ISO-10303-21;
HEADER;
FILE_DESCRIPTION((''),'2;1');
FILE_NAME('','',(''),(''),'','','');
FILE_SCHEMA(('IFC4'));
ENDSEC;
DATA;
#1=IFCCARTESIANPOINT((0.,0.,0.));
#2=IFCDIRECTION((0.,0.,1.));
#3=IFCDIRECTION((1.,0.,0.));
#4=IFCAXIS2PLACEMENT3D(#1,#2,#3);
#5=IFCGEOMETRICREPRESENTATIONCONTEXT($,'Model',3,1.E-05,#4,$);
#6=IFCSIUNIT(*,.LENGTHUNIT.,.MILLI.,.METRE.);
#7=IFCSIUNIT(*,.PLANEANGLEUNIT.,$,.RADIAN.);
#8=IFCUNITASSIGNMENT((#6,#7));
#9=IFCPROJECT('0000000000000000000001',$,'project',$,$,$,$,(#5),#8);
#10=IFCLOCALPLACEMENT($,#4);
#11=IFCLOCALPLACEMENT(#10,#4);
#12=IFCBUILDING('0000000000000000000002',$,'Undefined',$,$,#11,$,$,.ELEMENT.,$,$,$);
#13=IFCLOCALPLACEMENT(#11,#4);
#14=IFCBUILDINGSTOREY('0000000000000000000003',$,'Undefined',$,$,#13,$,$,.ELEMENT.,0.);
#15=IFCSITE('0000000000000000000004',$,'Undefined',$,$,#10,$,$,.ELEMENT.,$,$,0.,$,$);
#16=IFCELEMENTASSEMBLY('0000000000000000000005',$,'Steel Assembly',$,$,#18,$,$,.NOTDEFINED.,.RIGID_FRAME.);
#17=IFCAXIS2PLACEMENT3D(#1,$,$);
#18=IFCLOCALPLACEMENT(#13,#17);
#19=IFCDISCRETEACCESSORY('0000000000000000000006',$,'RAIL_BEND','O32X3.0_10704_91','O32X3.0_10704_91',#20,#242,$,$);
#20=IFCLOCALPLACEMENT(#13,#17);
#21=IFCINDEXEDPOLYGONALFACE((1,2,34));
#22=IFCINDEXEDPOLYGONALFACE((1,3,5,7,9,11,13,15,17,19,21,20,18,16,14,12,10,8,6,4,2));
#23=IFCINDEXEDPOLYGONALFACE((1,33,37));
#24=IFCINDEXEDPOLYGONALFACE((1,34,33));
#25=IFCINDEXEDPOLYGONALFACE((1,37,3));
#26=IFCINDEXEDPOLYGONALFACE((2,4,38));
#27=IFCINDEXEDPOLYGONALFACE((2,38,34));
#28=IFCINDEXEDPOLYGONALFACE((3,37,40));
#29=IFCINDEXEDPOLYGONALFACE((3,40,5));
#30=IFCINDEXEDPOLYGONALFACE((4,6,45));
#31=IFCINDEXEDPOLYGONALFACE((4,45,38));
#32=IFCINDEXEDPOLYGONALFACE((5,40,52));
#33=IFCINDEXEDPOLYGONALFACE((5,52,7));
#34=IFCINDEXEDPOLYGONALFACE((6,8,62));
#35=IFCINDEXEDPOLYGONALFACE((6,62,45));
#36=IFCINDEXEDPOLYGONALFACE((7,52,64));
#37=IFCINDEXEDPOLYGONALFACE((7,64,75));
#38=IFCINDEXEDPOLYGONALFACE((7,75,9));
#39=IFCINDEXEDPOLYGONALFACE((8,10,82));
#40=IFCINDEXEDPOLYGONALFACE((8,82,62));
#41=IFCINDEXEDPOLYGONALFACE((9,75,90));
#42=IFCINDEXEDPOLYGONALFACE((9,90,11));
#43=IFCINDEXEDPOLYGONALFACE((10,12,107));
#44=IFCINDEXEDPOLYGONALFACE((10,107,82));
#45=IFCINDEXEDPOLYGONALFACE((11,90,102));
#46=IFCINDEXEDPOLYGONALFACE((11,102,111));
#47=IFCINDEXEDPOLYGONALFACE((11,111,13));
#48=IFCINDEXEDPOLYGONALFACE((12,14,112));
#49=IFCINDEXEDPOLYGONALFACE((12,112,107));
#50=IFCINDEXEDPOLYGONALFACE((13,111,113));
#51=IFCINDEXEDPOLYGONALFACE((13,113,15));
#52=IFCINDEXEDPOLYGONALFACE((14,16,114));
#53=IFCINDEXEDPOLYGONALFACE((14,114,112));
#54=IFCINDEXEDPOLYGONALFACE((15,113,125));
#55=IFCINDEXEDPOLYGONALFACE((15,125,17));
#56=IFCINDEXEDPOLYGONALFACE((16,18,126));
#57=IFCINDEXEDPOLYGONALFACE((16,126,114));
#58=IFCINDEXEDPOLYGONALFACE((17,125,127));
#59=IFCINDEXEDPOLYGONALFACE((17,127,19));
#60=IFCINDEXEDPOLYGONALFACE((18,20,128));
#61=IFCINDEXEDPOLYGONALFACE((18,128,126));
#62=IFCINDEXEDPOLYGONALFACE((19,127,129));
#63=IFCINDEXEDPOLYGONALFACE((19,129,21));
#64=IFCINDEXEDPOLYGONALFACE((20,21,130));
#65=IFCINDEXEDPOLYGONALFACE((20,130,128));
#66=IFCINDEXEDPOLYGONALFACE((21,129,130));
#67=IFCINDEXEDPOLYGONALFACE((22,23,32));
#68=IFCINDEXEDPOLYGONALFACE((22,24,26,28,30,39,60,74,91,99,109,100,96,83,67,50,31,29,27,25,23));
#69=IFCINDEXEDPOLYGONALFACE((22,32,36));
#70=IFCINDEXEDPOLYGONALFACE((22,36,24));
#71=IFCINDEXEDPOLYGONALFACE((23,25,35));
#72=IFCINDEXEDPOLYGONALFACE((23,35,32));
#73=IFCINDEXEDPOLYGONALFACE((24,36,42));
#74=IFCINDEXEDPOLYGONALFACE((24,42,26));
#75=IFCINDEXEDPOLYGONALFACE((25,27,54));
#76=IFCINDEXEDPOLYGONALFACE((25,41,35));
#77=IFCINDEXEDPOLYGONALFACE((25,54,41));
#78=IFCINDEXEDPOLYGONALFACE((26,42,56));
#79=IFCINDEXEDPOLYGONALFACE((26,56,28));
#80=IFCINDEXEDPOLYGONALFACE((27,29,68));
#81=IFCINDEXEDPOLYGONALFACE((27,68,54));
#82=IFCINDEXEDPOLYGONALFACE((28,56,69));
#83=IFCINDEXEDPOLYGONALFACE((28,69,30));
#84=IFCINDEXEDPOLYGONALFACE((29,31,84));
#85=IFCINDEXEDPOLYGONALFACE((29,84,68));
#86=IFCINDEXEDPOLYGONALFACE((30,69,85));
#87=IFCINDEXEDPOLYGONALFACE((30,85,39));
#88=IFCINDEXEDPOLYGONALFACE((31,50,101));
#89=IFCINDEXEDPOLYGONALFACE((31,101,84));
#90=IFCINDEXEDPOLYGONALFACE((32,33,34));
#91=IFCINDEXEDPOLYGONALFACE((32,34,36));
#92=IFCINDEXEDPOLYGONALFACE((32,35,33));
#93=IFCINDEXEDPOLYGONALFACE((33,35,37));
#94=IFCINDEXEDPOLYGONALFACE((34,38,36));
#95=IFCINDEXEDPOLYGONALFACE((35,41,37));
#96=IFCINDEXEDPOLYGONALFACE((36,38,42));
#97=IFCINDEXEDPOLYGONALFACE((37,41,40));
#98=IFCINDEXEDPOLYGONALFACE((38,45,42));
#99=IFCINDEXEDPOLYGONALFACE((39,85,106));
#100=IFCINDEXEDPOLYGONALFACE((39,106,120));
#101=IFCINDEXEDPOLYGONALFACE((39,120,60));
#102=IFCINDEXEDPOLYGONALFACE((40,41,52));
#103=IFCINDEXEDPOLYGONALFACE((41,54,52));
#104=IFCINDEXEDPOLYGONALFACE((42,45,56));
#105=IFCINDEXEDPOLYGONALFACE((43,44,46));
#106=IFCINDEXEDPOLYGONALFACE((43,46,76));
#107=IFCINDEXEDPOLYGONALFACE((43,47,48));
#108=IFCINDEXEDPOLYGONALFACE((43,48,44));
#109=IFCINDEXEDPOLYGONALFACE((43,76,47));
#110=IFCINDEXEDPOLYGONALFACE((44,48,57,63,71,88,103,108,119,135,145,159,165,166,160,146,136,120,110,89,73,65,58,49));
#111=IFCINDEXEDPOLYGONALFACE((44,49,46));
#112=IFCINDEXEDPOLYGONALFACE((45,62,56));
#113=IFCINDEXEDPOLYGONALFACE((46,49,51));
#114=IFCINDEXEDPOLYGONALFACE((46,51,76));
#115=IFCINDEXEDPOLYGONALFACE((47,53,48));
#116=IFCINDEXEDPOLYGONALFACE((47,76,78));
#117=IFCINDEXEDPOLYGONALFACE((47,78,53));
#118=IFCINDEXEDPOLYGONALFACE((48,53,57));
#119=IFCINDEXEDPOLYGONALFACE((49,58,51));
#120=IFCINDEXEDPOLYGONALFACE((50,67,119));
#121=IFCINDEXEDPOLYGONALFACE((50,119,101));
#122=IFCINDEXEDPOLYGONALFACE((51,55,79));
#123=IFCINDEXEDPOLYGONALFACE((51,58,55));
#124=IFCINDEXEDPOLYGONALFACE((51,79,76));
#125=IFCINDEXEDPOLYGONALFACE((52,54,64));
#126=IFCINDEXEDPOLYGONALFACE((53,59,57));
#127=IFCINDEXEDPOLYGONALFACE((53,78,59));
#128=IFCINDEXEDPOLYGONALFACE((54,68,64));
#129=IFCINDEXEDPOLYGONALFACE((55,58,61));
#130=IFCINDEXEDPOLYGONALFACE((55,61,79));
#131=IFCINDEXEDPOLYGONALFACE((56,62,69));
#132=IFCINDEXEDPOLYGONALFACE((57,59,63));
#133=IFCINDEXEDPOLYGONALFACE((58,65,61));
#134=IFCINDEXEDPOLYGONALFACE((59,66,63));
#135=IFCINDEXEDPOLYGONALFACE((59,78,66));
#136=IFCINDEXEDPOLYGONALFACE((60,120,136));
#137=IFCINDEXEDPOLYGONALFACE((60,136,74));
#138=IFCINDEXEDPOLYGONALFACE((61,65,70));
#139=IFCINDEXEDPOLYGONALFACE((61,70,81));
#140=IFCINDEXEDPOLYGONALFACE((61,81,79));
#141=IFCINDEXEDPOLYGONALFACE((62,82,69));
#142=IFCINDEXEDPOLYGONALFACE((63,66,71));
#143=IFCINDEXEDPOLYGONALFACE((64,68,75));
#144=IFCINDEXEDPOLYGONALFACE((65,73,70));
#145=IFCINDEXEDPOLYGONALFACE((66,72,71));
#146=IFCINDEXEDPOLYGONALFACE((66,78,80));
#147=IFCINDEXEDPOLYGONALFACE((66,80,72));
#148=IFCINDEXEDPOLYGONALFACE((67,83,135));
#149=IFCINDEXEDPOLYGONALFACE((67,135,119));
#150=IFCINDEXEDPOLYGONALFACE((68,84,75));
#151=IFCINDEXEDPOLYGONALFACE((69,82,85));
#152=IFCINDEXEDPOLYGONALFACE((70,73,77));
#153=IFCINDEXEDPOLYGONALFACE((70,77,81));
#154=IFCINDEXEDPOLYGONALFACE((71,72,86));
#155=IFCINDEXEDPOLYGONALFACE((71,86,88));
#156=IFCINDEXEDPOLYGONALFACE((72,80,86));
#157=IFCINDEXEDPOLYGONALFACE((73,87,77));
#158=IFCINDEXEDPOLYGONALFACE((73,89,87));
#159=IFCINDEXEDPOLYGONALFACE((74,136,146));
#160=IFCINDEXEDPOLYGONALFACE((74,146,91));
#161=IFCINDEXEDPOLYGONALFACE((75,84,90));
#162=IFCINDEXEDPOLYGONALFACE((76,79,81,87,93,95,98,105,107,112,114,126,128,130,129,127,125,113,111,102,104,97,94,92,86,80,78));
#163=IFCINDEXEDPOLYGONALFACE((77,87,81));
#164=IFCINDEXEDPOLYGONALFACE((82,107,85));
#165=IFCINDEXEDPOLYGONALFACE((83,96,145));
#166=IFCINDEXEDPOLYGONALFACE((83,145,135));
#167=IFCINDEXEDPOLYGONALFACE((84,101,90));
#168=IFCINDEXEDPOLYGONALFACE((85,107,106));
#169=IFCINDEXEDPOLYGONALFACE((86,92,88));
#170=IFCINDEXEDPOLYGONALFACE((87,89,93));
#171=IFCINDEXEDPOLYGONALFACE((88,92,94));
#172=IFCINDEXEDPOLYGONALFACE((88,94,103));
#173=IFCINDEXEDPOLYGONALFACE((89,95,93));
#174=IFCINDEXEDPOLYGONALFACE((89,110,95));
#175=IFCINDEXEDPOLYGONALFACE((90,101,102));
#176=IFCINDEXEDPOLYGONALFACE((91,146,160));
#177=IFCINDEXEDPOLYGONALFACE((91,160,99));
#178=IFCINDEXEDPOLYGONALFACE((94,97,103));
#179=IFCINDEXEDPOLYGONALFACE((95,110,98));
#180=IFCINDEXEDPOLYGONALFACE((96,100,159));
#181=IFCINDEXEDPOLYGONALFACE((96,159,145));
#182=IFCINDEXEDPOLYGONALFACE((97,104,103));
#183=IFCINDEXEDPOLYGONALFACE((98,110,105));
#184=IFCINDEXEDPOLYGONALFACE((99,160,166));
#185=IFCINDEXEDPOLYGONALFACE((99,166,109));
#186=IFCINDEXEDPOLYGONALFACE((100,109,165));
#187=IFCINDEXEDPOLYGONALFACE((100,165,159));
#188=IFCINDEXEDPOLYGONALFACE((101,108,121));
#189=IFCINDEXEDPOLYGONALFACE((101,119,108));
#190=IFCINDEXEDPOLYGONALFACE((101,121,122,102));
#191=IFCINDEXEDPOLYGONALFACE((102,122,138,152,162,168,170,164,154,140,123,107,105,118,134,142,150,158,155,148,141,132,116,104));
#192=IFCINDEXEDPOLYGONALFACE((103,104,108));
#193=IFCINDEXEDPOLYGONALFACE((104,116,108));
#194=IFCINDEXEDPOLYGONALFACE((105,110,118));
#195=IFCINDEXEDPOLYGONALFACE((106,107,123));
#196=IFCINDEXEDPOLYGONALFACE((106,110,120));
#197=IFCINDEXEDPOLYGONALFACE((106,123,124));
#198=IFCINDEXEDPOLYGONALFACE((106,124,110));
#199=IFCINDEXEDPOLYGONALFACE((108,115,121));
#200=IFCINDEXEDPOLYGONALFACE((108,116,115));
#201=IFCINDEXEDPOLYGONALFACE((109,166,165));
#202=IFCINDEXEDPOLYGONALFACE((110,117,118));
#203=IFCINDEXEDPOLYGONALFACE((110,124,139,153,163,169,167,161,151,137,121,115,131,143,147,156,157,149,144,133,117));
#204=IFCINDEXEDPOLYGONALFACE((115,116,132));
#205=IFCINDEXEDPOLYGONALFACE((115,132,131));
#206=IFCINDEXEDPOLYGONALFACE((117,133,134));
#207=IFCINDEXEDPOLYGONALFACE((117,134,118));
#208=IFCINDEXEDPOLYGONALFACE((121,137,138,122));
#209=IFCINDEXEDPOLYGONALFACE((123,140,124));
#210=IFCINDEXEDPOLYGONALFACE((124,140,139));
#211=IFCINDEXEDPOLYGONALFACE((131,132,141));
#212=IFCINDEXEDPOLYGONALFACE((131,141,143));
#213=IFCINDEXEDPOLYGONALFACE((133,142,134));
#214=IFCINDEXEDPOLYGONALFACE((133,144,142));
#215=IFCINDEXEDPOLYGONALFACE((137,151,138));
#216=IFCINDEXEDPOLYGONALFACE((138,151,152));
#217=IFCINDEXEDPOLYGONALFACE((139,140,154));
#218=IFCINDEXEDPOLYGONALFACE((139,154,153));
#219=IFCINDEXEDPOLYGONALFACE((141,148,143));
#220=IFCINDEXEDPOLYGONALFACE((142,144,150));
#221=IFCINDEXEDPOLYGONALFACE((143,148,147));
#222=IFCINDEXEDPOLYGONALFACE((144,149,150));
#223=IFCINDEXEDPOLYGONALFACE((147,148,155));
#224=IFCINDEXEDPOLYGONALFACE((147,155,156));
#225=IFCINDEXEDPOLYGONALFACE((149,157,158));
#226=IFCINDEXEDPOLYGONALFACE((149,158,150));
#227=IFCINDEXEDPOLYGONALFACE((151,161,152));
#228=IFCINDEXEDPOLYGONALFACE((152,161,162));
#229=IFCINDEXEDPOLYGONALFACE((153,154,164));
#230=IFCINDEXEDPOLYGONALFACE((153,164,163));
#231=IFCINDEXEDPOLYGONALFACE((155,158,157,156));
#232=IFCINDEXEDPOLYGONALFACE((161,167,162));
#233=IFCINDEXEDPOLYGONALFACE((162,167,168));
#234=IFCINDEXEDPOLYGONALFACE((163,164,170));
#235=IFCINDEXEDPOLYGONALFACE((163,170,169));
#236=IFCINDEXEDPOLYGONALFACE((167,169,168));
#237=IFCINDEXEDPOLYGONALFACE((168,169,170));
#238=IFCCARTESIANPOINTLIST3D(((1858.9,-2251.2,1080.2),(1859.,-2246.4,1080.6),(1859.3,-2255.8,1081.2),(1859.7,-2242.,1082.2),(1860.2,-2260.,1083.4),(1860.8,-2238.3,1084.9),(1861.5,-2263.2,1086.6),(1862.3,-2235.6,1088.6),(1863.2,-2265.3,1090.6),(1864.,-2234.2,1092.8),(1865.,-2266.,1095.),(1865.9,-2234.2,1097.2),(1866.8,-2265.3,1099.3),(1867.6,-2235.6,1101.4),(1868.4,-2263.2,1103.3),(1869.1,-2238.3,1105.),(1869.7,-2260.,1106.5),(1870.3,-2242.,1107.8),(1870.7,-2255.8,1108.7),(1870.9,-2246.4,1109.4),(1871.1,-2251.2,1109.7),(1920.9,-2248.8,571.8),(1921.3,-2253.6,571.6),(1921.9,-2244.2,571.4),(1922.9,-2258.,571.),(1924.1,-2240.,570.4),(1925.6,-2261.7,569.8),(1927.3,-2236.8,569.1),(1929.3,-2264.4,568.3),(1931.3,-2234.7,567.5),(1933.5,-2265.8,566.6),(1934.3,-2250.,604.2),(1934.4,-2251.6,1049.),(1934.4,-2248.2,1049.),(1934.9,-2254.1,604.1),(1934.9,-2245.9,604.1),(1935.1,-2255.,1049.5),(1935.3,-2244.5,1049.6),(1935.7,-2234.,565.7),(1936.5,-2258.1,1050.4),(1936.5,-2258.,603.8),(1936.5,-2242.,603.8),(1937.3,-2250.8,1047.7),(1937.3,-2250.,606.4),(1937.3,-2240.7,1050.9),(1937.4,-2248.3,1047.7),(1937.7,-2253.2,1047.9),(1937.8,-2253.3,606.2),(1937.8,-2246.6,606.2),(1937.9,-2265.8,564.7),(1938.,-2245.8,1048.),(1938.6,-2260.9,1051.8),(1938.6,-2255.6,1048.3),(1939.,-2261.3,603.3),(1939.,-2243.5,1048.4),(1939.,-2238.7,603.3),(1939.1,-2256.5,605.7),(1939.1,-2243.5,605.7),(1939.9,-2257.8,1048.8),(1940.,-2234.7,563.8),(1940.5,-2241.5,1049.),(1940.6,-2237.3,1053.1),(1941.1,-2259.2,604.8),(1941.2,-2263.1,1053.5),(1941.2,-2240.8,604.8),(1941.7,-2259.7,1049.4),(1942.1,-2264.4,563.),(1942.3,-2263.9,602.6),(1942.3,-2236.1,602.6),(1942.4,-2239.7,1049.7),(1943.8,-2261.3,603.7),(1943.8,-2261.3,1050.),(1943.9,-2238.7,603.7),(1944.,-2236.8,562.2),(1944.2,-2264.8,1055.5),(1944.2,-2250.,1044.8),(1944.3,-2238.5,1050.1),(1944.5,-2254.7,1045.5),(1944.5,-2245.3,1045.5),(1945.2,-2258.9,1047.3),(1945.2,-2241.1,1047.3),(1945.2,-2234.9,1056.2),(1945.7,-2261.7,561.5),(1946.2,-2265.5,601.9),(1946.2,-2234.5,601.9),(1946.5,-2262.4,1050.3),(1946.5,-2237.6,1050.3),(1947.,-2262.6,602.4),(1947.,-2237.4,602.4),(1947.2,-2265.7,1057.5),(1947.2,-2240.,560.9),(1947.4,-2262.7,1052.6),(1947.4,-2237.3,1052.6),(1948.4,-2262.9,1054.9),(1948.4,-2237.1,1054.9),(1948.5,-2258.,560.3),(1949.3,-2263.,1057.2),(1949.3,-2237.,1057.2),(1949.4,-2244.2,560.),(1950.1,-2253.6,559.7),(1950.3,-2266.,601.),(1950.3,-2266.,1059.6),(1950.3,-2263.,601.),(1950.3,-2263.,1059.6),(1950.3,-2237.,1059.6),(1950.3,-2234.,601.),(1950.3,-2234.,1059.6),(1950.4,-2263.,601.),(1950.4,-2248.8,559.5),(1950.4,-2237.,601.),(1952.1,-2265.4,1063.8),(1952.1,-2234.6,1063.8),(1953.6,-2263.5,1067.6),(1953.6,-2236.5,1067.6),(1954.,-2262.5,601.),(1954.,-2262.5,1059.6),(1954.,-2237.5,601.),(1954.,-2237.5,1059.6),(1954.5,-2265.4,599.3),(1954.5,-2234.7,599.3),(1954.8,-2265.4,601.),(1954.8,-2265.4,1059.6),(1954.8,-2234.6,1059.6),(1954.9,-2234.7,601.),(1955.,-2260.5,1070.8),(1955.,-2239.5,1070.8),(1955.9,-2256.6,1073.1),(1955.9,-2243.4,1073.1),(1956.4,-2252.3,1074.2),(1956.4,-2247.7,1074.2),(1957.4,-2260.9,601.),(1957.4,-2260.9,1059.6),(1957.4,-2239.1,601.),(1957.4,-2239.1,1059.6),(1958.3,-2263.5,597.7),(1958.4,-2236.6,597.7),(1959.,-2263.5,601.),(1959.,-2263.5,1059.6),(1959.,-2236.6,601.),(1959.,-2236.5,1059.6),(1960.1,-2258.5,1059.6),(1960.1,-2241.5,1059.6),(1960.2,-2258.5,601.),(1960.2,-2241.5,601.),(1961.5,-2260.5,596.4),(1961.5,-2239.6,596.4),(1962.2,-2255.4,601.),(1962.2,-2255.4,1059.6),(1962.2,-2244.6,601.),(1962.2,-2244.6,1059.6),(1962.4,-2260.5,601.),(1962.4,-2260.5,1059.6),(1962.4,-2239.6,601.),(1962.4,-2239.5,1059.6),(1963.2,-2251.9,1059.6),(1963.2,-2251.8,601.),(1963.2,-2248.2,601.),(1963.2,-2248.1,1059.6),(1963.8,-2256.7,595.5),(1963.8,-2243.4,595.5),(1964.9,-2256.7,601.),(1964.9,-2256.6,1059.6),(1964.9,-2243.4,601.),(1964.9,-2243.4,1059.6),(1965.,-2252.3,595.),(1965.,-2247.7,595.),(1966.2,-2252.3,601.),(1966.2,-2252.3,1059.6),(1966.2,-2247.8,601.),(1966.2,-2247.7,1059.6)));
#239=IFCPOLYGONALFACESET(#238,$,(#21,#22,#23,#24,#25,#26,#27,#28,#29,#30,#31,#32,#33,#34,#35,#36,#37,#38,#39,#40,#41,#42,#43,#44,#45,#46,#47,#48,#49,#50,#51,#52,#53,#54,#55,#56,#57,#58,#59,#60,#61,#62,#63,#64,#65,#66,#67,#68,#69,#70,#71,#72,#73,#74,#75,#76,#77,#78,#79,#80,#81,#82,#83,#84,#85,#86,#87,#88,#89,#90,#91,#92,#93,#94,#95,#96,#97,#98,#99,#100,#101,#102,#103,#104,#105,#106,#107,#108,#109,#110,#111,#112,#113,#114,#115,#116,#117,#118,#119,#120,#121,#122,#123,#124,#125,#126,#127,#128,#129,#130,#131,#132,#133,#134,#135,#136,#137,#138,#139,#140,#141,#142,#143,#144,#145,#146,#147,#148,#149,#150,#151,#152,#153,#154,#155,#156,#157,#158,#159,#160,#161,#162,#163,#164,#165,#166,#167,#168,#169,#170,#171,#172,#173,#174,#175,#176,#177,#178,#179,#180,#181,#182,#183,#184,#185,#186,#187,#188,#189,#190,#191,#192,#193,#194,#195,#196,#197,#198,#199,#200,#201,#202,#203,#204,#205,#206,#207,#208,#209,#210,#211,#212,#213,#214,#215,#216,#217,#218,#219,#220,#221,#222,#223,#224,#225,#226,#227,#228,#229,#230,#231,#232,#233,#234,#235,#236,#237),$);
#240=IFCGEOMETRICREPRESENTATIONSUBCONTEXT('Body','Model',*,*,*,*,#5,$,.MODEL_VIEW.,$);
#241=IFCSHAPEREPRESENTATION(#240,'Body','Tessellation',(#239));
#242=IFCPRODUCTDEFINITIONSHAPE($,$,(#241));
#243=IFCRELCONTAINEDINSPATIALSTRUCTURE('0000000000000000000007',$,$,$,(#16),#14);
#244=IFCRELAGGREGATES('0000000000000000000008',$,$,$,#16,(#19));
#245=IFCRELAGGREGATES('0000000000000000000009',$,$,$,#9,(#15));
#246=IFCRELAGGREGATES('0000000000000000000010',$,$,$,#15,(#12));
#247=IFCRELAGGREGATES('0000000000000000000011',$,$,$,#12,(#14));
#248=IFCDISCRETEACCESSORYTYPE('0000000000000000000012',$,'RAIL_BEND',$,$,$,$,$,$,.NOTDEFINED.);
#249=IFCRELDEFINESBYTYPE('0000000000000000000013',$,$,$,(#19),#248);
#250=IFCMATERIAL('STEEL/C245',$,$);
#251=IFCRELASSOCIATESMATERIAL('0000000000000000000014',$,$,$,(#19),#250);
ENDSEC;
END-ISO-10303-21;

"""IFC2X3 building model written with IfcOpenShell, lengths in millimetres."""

from ifc_helpers import new_model, si_unit, frame, origin_with_axes, origin_2d_with_axis, place, context, subcontext, project, spatial, circle, hollow_circle, extrude, boolean, material, type_object, element, aggregate, save


model = new_model("IFC2X3")

# Units and contexts
model_context = context("Model", 3, precision=1e-05, world=origin_with_axes())
body_context = subcontext(model_context, "Body", "Model", "MODEL_VIEW")
ifc_project = project(units=[si_unit("LENGTHUNIT", "METRE", prefix="MILLI"), si_unit("PLANEANGLEUNIT", "RADIAN")], contexts=[model_context])

# Site, building, storey
site_placement = place(None, origin_with_axes())
site = spatial("IfcSite", under=ifc_project, at=site_placement, Name="Undefined", CompositionType="ELEMENT", RefElevation=0.0)
building_placement = place(site_placement, origin_with_axes())
building = spatial("IfcBuilding", under=site, at=building_placement, Name="Undefined", CompositionType="ELEMENT")
storey_placement = place(building_placement, origin_with_axes())
storey = spatial("IfcBuildingStorey", under=building, at=storey_placement, Name="Undefined", CompositionType="ELEMENT", Elevation=0.0)

# Shared definitions
ifc_material_1 = material(Name="STEEL/C245")

# Element assembly, discrete accessory
assembly_1_placement = place(storey_placement, origin_with_axes())
assembly_1 = element("IfcElementAssembly", 1, at=assembly_1_placement, inside=storey, Name="Steel Assembly", AssemblyPlace="NOTDEFINED", PredefinedType="RIGID_FRAME")
discrete_accessory_type_1 = type_object("IfcDiscreteAccessoryType", Name="RAIL_BEND")
discrete_accessory_1_placement = place(assembly_1_placement, frame((1950.3, -2250.0, 601.0), z_axis=(0.0, 0.0, 1.0), x_axis=(-1.0, 0.0, 0.0)))
discrete_accessory_1 = element("IfcDiscreteAccessory", 2, at=discrete_accessory_1_placement, type_object=discrete_accessory_type_1, material=ifc_material_1, Name="RAIL_BEND", Description="O32X3.0_10704_91", ObjectType="O32X3.0_10704_91", context=body_context, shape_type="CSG", body=[
    boolean("UNION", boolean("UNION", extrude(hollow_circle(Radius=16.0, WallThickness=3.0, at=origin_2d_with_axis()), frame((0.0, 0.0, 458.6), z_axis=(0.0, 0.0, -1.0), x_axis=(0.0, 1.0, 0.0)), (0.0, 0.0, 1.0), 458.6), extrude(circle(Radius=16.0, at=origin_2d_with_axis()), frame((0.0, 0.0, 458.6), z_axis=(0.92388, 0.0, 0.382683), x_axis=(0.0, 1.0, 0.0)), (0.0, 0.0, 1.0), 92.4)), extrude(circle(Radius=16.0, at=origin_2d_with_axis()), frame((0.0, 0.0, 0.0), z_axis=(0.382683, 0.0, -0.92388), x_axis=(0.0, -1.0, 0.0)), (0.0, 0.0, 1.0), 38.3)),
])
aggregate(assembly_1, [discrete_accessory_1])

save(model, "model.ifc")
